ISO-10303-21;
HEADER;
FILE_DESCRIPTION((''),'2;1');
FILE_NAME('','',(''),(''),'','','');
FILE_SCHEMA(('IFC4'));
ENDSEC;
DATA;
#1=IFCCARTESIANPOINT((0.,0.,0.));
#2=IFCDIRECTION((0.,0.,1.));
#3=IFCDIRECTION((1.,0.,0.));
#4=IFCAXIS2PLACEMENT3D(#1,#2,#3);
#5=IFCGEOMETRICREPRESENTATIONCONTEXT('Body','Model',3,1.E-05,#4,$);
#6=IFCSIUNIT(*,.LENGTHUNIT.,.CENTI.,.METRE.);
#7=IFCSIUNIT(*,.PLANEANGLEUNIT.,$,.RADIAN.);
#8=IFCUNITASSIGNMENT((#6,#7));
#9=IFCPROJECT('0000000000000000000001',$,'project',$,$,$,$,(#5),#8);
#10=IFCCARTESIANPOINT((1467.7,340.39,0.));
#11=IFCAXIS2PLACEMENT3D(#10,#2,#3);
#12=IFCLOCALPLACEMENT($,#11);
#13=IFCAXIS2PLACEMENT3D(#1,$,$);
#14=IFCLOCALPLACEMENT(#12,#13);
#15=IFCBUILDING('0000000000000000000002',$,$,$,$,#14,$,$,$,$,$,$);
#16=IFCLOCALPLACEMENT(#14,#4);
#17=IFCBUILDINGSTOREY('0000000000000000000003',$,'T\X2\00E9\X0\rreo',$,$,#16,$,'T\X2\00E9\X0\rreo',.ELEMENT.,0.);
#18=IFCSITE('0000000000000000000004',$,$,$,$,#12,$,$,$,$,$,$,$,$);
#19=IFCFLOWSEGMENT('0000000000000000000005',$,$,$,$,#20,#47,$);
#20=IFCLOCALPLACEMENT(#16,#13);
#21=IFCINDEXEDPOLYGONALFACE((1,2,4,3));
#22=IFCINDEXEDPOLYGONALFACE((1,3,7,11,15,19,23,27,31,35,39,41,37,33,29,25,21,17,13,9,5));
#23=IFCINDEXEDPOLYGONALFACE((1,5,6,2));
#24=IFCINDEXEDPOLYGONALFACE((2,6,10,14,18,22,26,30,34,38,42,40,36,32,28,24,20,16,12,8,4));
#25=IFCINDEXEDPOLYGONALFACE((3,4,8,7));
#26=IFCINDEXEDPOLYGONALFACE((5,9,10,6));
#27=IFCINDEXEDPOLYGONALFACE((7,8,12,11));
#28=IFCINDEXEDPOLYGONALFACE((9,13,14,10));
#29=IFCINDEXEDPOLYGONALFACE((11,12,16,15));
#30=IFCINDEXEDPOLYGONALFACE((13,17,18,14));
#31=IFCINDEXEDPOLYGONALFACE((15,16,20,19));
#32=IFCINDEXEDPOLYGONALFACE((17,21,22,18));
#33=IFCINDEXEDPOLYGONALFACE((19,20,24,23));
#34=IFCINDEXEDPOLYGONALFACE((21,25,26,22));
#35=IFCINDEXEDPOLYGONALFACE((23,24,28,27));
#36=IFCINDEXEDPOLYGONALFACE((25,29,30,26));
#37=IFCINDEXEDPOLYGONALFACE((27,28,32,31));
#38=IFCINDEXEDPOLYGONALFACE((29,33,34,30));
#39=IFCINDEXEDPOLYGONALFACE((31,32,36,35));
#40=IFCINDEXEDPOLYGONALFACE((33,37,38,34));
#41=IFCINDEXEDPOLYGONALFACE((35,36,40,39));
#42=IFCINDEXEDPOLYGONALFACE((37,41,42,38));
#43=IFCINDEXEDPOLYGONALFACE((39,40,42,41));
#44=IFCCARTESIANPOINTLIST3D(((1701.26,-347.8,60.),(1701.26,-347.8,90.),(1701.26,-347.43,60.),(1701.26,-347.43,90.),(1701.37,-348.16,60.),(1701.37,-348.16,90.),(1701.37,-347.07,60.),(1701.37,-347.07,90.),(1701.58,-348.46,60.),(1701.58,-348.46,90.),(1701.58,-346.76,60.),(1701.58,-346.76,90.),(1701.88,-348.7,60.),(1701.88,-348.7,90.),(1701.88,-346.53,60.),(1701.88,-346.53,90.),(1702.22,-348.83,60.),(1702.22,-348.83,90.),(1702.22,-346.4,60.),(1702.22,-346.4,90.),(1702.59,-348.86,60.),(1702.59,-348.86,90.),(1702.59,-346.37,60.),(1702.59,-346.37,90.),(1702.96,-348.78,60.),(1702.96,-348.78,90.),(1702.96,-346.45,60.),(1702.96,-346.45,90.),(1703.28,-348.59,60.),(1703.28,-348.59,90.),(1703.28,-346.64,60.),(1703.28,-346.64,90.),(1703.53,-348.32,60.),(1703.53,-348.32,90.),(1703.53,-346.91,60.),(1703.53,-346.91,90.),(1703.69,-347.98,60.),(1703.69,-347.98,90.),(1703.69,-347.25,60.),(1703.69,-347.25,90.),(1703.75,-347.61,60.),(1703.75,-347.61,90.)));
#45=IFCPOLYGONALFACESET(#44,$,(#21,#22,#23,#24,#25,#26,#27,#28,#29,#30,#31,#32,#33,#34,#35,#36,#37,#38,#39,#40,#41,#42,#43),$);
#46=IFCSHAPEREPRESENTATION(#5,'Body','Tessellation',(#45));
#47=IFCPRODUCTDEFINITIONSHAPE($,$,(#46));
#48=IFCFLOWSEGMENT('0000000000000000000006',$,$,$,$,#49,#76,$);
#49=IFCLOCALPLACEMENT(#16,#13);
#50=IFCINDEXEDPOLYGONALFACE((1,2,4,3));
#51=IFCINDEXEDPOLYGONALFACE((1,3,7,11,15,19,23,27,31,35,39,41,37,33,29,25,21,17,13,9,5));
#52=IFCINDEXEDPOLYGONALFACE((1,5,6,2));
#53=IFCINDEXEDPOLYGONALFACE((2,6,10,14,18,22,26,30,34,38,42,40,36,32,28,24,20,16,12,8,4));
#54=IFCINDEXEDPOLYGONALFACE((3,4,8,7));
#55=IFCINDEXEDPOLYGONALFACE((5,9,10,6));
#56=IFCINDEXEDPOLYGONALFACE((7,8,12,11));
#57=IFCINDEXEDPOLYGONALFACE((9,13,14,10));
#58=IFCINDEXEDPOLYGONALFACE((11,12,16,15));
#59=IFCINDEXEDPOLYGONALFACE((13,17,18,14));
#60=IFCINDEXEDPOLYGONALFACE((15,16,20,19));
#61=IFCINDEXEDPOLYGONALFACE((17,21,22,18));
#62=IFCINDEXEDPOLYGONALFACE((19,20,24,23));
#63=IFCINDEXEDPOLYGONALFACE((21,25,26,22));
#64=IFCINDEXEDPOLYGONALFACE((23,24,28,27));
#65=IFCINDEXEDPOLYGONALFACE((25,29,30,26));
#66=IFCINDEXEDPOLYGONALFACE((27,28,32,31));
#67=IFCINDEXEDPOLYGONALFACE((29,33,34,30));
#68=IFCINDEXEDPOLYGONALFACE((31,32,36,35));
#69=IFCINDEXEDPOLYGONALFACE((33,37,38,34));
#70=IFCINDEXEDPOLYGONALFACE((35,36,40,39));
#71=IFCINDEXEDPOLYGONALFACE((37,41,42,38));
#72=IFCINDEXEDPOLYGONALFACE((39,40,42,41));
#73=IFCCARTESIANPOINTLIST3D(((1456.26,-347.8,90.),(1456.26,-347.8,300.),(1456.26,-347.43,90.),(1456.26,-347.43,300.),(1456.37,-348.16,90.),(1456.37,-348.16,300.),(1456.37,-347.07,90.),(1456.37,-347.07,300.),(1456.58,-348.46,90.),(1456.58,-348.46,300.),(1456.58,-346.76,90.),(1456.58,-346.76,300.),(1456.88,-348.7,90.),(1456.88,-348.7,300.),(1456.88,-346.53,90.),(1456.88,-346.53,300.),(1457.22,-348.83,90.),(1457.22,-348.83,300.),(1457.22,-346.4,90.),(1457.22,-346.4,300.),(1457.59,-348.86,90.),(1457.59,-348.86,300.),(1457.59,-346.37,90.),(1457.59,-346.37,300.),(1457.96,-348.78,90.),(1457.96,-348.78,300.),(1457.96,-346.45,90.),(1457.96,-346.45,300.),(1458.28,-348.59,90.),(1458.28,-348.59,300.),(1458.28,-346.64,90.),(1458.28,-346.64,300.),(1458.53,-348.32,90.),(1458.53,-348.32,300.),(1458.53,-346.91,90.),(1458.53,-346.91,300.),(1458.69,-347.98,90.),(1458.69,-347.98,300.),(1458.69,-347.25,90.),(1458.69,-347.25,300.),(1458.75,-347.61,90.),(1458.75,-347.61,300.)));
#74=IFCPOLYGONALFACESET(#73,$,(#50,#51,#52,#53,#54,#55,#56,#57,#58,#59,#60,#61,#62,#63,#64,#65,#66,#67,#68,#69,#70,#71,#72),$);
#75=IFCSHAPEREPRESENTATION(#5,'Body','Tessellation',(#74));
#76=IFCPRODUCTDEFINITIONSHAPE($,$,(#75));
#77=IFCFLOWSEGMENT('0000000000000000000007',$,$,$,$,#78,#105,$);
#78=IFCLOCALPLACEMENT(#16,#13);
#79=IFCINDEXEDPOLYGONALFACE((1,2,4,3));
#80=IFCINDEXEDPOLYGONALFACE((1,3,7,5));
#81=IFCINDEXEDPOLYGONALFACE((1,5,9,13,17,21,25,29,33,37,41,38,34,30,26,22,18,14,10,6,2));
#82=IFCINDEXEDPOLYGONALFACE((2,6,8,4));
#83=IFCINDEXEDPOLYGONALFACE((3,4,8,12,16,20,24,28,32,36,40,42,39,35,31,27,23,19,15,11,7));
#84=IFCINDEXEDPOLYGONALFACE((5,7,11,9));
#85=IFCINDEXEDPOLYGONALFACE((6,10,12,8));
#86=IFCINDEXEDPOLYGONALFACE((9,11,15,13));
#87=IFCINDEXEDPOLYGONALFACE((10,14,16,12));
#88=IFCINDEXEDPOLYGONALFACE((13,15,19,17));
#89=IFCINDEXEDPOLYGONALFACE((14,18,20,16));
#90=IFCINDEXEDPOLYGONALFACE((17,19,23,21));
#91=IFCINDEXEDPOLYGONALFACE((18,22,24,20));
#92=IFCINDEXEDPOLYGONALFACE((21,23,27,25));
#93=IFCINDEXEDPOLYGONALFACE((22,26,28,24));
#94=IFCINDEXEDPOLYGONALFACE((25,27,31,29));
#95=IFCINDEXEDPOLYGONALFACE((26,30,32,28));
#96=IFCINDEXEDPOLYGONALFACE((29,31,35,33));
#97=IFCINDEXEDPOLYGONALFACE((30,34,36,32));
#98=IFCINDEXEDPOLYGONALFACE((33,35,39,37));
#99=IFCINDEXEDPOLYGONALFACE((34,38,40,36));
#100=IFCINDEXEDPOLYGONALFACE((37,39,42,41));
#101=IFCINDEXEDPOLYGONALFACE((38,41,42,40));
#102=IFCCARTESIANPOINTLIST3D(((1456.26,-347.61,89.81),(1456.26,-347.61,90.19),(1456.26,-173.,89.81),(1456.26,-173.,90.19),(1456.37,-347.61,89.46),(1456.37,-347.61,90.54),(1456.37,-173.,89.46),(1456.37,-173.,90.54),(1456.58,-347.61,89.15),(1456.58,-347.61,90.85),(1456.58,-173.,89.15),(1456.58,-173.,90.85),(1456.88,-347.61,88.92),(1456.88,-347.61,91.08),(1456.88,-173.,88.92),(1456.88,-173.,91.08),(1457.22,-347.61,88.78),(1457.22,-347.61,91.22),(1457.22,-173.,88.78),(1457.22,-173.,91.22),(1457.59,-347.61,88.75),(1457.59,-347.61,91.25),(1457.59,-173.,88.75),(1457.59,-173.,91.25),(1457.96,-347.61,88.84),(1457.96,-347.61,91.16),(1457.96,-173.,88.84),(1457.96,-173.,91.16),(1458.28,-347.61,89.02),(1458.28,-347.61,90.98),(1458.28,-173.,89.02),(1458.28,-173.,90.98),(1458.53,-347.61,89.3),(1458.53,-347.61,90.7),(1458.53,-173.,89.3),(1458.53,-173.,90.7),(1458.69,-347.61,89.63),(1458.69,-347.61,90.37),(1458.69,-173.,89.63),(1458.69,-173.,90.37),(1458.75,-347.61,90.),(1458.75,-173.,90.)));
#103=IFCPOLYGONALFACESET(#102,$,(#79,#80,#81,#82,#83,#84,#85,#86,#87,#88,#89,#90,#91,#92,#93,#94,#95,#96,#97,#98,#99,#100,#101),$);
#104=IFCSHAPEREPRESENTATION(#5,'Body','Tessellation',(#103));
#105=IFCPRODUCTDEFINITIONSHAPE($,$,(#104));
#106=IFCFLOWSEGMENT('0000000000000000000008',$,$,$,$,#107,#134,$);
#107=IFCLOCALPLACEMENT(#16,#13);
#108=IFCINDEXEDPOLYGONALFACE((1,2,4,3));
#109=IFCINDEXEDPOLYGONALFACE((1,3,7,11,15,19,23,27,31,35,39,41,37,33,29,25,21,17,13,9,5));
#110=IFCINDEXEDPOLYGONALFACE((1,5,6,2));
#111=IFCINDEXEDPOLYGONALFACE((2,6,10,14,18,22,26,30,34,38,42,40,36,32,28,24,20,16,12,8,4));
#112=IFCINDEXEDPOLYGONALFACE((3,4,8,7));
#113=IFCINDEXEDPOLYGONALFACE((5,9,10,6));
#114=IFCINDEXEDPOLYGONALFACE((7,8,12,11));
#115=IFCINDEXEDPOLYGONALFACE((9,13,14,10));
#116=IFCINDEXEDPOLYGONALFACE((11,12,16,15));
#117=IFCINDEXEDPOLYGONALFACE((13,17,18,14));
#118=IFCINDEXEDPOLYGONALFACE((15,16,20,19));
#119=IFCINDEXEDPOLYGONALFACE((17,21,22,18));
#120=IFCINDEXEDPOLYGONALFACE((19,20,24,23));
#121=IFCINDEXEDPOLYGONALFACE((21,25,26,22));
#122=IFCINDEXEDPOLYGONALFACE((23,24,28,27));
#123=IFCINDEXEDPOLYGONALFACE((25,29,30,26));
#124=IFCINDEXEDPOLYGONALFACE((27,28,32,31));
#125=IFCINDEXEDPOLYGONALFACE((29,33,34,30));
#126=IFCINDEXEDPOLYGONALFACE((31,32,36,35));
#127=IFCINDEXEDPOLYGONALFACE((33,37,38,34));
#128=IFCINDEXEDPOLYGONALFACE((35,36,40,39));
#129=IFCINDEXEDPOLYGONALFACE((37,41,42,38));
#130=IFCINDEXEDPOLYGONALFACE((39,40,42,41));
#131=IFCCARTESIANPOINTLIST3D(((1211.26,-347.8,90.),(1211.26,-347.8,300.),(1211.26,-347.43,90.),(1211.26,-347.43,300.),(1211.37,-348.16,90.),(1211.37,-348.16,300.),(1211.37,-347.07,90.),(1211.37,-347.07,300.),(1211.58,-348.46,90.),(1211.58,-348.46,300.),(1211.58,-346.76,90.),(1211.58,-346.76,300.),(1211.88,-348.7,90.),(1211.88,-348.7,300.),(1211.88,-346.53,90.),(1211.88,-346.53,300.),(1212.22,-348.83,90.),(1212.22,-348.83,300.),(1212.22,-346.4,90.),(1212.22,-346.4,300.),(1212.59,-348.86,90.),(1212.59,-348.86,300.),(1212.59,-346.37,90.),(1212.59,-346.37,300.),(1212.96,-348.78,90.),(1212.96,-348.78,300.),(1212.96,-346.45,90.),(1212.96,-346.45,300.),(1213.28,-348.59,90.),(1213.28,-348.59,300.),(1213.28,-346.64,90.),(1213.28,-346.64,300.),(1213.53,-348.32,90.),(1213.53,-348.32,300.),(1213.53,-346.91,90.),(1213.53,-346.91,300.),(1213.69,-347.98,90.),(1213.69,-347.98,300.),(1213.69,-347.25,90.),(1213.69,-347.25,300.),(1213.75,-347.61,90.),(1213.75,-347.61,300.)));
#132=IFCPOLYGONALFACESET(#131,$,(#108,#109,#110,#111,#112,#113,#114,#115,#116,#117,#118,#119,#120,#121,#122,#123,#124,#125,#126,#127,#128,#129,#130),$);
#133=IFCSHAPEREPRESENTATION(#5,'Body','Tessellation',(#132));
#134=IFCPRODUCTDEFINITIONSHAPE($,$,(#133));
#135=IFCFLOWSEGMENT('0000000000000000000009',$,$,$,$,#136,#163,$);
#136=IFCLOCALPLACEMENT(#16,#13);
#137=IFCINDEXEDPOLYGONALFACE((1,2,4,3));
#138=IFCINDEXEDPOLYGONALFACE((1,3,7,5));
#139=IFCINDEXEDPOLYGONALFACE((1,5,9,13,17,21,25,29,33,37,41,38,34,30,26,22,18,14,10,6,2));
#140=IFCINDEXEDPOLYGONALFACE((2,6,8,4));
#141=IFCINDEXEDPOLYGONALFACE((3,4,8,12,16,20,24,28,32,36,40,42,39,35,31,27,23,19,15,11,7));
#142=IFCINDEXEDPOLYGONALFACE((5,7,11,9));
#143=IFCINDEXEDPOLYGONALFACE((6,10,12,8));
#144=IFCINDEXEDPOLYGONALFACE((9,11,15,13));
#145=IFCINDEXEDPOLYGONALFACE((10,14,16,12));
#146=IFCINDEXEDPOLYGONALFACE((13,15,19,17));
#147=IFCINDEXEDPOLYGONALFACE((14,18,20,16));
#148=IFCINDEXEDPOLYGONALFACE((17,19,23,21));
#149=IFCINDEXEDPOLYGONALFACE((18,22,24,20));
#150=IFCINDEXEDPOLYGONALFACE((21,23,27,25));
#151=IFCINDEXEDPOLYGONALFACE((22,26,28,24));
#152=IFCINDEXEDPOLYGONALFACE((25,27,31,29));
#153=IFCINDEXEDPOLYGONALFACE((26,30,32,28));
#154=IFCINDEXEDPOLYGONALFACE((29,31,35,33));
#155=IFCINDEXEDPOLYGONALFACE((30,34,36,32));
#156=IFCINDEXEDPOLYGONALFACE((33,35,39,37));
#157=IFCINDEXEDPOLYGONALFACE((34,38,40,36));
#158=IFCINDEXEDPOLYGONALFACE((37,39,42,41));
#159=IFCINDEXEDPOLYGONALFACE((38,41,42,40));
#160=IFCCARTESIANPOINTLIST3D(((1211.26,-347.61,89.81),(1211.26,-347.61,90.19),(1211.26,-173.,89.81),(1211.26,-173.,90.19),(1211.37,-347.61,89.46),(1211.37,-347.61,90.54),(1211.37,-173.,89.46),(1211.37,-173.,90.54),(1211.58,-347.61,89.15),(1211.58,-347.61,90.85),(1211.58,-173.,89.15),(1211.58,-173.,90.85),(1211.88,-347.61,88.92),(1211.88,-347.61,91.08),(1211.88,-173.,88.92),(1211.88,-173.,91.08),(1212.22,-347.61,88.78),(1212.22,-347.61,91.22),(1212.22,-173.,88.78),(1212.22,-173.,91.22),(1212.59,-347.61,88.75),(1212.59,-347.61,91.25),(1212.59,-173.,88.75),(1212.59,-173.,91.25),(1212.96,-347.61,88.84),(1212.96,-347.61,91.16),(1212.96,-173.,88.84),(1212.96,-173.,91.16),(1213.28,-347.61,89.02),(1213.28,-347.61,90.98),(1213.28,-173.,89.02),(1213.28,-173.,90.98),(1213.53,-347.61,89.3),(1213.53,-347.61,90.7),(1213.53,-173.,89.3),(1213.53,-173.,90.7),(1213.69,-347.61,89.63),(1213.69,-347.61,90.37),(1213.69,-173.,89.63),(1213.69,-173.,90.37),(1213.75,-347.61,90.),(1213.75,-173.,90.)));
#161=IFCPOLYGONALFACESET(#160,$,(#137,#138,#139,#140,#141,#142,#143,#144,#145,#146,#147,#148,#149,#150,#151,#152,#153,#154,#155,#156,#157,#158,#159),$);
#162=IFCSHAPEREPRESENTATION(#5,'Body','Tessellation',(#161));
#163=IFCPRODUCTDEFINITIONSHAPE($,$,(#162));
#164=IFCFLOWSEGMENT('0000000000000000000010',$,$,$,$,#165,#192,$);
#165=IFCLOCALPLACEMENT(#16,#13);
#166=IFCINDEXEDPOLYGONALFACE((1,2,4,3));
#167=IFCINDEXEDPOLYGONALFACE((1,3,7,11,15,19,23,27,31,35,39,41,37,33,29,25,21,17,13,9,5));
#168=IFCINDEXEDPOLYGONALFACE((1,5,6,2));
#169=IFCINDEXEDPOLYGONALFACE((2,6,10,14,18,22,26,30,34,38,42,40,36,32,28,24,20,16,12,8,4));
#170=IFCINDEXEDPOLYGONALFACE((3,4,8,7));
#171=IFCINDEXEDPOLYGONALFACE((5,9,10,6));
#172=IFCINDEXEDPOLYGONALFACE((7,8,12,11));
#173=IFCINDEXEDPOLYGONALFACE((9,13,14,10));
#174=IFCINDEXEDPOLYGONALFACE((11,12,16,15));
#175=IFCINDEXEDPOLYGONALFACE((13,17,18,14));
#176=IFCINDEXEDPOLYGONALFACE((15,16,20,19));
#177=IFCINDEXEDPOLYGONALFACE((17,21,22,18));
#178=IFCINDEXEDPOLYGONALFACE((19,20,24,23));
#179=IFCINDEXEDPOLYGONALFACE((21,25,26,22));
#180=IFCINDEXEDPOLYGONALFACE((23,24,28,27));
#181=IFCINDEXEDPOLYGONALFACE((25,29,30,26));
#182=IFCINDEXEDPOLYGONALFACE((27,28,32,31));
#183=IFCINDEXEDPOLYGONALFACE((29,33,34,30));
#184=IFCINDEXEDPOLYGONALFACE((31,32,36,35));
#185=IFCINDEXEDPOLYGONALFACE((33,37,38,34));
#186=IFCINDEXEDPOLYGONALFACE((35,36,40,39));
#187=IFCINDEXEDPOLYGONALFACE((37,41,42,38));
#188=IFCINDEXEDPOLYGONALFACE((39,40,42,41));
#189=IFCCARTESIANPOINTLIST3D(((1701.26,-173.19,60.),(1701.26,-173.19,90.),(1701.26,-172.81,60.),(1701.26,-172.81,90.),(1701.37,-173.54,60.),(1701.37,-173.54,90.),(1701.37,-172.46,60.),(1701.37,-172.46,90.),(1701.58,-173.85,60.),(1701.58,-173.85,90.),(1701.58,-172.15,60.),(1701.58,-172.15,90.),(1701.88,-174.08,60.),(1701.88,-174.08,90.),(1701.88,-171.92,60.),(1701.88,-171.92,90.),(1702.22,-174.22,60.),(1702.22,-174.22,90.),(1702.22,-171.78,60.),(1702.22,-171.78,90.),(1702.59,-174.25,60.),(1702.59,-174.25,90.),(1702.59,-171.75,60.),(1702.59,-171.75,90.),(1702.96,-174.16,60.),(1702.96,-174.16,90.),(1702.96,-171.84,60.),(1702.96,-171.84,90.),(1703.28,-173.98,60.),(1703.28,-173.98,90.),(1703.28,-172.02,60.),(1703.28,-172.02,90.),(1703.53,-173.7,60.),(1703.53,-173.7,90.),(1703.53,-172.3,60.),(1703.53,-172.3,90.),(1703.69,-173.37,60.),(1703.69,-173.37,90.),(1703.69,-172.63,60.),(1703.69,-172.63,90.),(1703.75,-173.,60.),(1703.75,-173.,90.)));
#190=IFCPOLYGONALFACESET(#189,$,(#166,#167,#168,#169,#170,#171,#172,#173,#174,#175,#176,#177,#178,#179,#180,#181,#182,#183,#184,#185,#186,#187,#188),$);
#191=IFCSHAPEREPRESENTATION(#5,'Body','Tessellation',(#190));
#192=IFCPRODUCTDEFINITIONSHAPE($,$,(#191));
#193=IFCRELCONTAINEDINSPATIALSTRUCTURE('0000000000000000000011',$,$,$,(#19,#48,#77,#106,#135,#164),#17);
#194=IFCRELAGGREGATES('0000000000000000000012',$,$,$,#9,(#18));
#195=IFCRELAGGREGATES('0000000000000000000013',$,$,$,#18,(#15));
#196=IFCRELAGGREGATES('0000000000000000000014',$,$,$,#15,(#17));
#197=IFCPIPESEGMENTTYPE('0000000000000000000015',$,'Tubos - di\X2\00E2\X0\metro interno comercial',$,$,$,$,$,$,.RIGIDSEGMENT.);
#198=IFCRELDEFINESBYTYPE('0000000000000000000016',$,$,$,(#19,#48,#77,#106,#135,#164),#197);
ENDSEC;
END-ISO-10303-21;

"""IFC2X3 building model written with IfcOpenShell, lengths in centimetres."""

from ifc_helpers import new_model, si_unit, frame, origin, origin_with_axes, origin_2d_with_axis, place, context, project, spatial, circle, extrude, type_object, element, save


model = new_model("IFC2X3")

# Units and contexts
model_context = context("Model", 3, precision=1e-05, world=origin_with_axes(), identifier="Body")
ifc_project = project(units=[si_unit("LENGTHUNIT", "METRE", prefix="CENTI"), si_unit("PLANEANGLEUNIT", "RADIAN")], contexts=[model_context])

# Site, building, storey
site_placement = place(None, frame((1467.7, 340.39, 0.0), z_axis=(0.0, 0.0, 1.0), x_axis=(1.0, 0.0, 0.0)))
site = spatial("IfcSite", under=ifc_project, at=site_placement)
building_placement = place(site_placement, origin())
building = spatial("IfcBuilding", under=site, at=building_placement)
storey_placement = place(building_placement, origin_with_axes())
storey = spatial("IfcBuildingStorey", under=building, at=storey_placement, Name="Térreo", LongName="Térreo", CompositionType="ELEMENT", Elevation=0.0)

# Flow segments
pipe_segment_type = type_object("IfcPipeSegmentType", Name="Tubos - diâmetro interno comercial", PredefinedType="RIGIDSEGMENT")
flow_segment_1_placement = place(storey_placement, frame((1702.5, -347.61, 90.0), z_axis=(0.0, 0.0, 1.0), x_axis=(1.0, 0.0, 0.0)))
element("IfcFlowSegment", 1, at=flow_segment_1_placement, inside=storey, type_object=pipe_segment_type, context=model_context, shape_type="SolidModel", body=[
    extrude(circle(Radius=1.25, at=origin_2d_with_axis()), frame((0.0, 0.0, 0.0), z_axis=(0.0, 0.0, -1.0), x_axis=(1.0, 0.0, 0.0)), (0.0, 0.0, 1.0), 30.0),
])
flow_segment_2_placement = place(storey_placement, frame((1457.5, -347.61, 300.0), z_axis=(0.0, 0.0, 1.0), x_axis=(1.0, 0.0, 0.0)))
element("IfcFlowSegment", 2, at=flow_segment_2_placement, inside=storey, type_object=pipe_segment_type, context=model_context, shape_type="SolidModel", body=[
    extrude(circle(Radius=1.25, at=origin_2d_with_axis()), frame((0.0, 0.0, 0.0), z_axis=(0.0, 0.0, -1.0), x_axis=(1.0, 0.0, 0.0)), (0.0, 0.0, 1.0), 210.0),
])
flow_segment_3_placement = place(storey_placement, frame((1457.5, -260.31, 91.25), z_axis=(0.0, 0.0, 1.0), x_axis=(1.0, 0.0, 0.0)))
element("IfcFlowSegment", 3, at=flow_segment_3_placement, inside=storey, type_object=pipe_segment_type, context=model_context, shape_type="SolidModel", body=[
    extrude(circle(Radius=1.25, at=origin_2d_with_axis()), frame((0.0, -87.31, -1.25), z_axis=(0.0, 1.0, 0.0), x_axis=(1.0, 0.0, 0.0)), (0.0, 0.0, 1.0), 174.61),
])
flow_segment_4_placement = place(storey_placement, frame((1212.5, -347.61, 300.0), z_axis=(0.0, 0.0, 1.0), x_axis=(1.0, 0.0, 0.0)))
element("IfcFlowSegment", 4, at=flow_segment_4_placement, inside=storey, type_object=pipe_segment_type, context=model_context, shape_type="SolidModel", body=[
    extrude(circle(Radius=1.25, at=origin_2d_with_axis()), frame((0.0, 0.0, 0.0), z_axis=(0.0, 0.0, -1.0), x_axis=(1.0, 0.0, 0.0)), (0.0, 0.0, 1.0), 210.0),
])
flow_segment_5_placement = place(storey_placement, frame((1212.5, -260.31, 91.25), z_axis=(0.0, 0.0, 1.0), x_axis=(1.0, 0.0, 0.0)))
element("IfcFlowSegment", 5, at=flow_segment_5_placement, inside=storey, type_object=pipe_segment_type, context=model_context, shape_type="SolidModel", body=[
    extrude(circle(Radius=1.25, at=origin_2d_with_axis()), frame((0.0, -87.31, -1.25), z_axis=(0.0, 1.0, 0.0), x_axis=(1.0, 0.0, 0.0)), (0.0, 0.0, 1.0), 174.61),
])
for number, where, z_axis, x_axis in (
    (6, (1702.5, -173.0, 90.0), (0.0, 0.0, 1.0), (1.0, 0.0, 0.0)),
):
    element("IfcFlowSegment", number, at=place(storey_placement, frame(where, z_axis=z_axis, x_axis=x_axis)), inside=storey, type_object=pipe_segment_type, context=model_context, shape_type="SolidModel", body=[
        extrude(circle(Radius=1.25, at=origin_2d_with_axis()), frame((0.0, 0.0, 0.0), z_axis=(0.0, 0.0, -1.0), x_axis=(1.0, 0.0, 0.0)), (0.0, 0.0, 1.0), 30.0),
    ])

save(model, "model.ifc")
